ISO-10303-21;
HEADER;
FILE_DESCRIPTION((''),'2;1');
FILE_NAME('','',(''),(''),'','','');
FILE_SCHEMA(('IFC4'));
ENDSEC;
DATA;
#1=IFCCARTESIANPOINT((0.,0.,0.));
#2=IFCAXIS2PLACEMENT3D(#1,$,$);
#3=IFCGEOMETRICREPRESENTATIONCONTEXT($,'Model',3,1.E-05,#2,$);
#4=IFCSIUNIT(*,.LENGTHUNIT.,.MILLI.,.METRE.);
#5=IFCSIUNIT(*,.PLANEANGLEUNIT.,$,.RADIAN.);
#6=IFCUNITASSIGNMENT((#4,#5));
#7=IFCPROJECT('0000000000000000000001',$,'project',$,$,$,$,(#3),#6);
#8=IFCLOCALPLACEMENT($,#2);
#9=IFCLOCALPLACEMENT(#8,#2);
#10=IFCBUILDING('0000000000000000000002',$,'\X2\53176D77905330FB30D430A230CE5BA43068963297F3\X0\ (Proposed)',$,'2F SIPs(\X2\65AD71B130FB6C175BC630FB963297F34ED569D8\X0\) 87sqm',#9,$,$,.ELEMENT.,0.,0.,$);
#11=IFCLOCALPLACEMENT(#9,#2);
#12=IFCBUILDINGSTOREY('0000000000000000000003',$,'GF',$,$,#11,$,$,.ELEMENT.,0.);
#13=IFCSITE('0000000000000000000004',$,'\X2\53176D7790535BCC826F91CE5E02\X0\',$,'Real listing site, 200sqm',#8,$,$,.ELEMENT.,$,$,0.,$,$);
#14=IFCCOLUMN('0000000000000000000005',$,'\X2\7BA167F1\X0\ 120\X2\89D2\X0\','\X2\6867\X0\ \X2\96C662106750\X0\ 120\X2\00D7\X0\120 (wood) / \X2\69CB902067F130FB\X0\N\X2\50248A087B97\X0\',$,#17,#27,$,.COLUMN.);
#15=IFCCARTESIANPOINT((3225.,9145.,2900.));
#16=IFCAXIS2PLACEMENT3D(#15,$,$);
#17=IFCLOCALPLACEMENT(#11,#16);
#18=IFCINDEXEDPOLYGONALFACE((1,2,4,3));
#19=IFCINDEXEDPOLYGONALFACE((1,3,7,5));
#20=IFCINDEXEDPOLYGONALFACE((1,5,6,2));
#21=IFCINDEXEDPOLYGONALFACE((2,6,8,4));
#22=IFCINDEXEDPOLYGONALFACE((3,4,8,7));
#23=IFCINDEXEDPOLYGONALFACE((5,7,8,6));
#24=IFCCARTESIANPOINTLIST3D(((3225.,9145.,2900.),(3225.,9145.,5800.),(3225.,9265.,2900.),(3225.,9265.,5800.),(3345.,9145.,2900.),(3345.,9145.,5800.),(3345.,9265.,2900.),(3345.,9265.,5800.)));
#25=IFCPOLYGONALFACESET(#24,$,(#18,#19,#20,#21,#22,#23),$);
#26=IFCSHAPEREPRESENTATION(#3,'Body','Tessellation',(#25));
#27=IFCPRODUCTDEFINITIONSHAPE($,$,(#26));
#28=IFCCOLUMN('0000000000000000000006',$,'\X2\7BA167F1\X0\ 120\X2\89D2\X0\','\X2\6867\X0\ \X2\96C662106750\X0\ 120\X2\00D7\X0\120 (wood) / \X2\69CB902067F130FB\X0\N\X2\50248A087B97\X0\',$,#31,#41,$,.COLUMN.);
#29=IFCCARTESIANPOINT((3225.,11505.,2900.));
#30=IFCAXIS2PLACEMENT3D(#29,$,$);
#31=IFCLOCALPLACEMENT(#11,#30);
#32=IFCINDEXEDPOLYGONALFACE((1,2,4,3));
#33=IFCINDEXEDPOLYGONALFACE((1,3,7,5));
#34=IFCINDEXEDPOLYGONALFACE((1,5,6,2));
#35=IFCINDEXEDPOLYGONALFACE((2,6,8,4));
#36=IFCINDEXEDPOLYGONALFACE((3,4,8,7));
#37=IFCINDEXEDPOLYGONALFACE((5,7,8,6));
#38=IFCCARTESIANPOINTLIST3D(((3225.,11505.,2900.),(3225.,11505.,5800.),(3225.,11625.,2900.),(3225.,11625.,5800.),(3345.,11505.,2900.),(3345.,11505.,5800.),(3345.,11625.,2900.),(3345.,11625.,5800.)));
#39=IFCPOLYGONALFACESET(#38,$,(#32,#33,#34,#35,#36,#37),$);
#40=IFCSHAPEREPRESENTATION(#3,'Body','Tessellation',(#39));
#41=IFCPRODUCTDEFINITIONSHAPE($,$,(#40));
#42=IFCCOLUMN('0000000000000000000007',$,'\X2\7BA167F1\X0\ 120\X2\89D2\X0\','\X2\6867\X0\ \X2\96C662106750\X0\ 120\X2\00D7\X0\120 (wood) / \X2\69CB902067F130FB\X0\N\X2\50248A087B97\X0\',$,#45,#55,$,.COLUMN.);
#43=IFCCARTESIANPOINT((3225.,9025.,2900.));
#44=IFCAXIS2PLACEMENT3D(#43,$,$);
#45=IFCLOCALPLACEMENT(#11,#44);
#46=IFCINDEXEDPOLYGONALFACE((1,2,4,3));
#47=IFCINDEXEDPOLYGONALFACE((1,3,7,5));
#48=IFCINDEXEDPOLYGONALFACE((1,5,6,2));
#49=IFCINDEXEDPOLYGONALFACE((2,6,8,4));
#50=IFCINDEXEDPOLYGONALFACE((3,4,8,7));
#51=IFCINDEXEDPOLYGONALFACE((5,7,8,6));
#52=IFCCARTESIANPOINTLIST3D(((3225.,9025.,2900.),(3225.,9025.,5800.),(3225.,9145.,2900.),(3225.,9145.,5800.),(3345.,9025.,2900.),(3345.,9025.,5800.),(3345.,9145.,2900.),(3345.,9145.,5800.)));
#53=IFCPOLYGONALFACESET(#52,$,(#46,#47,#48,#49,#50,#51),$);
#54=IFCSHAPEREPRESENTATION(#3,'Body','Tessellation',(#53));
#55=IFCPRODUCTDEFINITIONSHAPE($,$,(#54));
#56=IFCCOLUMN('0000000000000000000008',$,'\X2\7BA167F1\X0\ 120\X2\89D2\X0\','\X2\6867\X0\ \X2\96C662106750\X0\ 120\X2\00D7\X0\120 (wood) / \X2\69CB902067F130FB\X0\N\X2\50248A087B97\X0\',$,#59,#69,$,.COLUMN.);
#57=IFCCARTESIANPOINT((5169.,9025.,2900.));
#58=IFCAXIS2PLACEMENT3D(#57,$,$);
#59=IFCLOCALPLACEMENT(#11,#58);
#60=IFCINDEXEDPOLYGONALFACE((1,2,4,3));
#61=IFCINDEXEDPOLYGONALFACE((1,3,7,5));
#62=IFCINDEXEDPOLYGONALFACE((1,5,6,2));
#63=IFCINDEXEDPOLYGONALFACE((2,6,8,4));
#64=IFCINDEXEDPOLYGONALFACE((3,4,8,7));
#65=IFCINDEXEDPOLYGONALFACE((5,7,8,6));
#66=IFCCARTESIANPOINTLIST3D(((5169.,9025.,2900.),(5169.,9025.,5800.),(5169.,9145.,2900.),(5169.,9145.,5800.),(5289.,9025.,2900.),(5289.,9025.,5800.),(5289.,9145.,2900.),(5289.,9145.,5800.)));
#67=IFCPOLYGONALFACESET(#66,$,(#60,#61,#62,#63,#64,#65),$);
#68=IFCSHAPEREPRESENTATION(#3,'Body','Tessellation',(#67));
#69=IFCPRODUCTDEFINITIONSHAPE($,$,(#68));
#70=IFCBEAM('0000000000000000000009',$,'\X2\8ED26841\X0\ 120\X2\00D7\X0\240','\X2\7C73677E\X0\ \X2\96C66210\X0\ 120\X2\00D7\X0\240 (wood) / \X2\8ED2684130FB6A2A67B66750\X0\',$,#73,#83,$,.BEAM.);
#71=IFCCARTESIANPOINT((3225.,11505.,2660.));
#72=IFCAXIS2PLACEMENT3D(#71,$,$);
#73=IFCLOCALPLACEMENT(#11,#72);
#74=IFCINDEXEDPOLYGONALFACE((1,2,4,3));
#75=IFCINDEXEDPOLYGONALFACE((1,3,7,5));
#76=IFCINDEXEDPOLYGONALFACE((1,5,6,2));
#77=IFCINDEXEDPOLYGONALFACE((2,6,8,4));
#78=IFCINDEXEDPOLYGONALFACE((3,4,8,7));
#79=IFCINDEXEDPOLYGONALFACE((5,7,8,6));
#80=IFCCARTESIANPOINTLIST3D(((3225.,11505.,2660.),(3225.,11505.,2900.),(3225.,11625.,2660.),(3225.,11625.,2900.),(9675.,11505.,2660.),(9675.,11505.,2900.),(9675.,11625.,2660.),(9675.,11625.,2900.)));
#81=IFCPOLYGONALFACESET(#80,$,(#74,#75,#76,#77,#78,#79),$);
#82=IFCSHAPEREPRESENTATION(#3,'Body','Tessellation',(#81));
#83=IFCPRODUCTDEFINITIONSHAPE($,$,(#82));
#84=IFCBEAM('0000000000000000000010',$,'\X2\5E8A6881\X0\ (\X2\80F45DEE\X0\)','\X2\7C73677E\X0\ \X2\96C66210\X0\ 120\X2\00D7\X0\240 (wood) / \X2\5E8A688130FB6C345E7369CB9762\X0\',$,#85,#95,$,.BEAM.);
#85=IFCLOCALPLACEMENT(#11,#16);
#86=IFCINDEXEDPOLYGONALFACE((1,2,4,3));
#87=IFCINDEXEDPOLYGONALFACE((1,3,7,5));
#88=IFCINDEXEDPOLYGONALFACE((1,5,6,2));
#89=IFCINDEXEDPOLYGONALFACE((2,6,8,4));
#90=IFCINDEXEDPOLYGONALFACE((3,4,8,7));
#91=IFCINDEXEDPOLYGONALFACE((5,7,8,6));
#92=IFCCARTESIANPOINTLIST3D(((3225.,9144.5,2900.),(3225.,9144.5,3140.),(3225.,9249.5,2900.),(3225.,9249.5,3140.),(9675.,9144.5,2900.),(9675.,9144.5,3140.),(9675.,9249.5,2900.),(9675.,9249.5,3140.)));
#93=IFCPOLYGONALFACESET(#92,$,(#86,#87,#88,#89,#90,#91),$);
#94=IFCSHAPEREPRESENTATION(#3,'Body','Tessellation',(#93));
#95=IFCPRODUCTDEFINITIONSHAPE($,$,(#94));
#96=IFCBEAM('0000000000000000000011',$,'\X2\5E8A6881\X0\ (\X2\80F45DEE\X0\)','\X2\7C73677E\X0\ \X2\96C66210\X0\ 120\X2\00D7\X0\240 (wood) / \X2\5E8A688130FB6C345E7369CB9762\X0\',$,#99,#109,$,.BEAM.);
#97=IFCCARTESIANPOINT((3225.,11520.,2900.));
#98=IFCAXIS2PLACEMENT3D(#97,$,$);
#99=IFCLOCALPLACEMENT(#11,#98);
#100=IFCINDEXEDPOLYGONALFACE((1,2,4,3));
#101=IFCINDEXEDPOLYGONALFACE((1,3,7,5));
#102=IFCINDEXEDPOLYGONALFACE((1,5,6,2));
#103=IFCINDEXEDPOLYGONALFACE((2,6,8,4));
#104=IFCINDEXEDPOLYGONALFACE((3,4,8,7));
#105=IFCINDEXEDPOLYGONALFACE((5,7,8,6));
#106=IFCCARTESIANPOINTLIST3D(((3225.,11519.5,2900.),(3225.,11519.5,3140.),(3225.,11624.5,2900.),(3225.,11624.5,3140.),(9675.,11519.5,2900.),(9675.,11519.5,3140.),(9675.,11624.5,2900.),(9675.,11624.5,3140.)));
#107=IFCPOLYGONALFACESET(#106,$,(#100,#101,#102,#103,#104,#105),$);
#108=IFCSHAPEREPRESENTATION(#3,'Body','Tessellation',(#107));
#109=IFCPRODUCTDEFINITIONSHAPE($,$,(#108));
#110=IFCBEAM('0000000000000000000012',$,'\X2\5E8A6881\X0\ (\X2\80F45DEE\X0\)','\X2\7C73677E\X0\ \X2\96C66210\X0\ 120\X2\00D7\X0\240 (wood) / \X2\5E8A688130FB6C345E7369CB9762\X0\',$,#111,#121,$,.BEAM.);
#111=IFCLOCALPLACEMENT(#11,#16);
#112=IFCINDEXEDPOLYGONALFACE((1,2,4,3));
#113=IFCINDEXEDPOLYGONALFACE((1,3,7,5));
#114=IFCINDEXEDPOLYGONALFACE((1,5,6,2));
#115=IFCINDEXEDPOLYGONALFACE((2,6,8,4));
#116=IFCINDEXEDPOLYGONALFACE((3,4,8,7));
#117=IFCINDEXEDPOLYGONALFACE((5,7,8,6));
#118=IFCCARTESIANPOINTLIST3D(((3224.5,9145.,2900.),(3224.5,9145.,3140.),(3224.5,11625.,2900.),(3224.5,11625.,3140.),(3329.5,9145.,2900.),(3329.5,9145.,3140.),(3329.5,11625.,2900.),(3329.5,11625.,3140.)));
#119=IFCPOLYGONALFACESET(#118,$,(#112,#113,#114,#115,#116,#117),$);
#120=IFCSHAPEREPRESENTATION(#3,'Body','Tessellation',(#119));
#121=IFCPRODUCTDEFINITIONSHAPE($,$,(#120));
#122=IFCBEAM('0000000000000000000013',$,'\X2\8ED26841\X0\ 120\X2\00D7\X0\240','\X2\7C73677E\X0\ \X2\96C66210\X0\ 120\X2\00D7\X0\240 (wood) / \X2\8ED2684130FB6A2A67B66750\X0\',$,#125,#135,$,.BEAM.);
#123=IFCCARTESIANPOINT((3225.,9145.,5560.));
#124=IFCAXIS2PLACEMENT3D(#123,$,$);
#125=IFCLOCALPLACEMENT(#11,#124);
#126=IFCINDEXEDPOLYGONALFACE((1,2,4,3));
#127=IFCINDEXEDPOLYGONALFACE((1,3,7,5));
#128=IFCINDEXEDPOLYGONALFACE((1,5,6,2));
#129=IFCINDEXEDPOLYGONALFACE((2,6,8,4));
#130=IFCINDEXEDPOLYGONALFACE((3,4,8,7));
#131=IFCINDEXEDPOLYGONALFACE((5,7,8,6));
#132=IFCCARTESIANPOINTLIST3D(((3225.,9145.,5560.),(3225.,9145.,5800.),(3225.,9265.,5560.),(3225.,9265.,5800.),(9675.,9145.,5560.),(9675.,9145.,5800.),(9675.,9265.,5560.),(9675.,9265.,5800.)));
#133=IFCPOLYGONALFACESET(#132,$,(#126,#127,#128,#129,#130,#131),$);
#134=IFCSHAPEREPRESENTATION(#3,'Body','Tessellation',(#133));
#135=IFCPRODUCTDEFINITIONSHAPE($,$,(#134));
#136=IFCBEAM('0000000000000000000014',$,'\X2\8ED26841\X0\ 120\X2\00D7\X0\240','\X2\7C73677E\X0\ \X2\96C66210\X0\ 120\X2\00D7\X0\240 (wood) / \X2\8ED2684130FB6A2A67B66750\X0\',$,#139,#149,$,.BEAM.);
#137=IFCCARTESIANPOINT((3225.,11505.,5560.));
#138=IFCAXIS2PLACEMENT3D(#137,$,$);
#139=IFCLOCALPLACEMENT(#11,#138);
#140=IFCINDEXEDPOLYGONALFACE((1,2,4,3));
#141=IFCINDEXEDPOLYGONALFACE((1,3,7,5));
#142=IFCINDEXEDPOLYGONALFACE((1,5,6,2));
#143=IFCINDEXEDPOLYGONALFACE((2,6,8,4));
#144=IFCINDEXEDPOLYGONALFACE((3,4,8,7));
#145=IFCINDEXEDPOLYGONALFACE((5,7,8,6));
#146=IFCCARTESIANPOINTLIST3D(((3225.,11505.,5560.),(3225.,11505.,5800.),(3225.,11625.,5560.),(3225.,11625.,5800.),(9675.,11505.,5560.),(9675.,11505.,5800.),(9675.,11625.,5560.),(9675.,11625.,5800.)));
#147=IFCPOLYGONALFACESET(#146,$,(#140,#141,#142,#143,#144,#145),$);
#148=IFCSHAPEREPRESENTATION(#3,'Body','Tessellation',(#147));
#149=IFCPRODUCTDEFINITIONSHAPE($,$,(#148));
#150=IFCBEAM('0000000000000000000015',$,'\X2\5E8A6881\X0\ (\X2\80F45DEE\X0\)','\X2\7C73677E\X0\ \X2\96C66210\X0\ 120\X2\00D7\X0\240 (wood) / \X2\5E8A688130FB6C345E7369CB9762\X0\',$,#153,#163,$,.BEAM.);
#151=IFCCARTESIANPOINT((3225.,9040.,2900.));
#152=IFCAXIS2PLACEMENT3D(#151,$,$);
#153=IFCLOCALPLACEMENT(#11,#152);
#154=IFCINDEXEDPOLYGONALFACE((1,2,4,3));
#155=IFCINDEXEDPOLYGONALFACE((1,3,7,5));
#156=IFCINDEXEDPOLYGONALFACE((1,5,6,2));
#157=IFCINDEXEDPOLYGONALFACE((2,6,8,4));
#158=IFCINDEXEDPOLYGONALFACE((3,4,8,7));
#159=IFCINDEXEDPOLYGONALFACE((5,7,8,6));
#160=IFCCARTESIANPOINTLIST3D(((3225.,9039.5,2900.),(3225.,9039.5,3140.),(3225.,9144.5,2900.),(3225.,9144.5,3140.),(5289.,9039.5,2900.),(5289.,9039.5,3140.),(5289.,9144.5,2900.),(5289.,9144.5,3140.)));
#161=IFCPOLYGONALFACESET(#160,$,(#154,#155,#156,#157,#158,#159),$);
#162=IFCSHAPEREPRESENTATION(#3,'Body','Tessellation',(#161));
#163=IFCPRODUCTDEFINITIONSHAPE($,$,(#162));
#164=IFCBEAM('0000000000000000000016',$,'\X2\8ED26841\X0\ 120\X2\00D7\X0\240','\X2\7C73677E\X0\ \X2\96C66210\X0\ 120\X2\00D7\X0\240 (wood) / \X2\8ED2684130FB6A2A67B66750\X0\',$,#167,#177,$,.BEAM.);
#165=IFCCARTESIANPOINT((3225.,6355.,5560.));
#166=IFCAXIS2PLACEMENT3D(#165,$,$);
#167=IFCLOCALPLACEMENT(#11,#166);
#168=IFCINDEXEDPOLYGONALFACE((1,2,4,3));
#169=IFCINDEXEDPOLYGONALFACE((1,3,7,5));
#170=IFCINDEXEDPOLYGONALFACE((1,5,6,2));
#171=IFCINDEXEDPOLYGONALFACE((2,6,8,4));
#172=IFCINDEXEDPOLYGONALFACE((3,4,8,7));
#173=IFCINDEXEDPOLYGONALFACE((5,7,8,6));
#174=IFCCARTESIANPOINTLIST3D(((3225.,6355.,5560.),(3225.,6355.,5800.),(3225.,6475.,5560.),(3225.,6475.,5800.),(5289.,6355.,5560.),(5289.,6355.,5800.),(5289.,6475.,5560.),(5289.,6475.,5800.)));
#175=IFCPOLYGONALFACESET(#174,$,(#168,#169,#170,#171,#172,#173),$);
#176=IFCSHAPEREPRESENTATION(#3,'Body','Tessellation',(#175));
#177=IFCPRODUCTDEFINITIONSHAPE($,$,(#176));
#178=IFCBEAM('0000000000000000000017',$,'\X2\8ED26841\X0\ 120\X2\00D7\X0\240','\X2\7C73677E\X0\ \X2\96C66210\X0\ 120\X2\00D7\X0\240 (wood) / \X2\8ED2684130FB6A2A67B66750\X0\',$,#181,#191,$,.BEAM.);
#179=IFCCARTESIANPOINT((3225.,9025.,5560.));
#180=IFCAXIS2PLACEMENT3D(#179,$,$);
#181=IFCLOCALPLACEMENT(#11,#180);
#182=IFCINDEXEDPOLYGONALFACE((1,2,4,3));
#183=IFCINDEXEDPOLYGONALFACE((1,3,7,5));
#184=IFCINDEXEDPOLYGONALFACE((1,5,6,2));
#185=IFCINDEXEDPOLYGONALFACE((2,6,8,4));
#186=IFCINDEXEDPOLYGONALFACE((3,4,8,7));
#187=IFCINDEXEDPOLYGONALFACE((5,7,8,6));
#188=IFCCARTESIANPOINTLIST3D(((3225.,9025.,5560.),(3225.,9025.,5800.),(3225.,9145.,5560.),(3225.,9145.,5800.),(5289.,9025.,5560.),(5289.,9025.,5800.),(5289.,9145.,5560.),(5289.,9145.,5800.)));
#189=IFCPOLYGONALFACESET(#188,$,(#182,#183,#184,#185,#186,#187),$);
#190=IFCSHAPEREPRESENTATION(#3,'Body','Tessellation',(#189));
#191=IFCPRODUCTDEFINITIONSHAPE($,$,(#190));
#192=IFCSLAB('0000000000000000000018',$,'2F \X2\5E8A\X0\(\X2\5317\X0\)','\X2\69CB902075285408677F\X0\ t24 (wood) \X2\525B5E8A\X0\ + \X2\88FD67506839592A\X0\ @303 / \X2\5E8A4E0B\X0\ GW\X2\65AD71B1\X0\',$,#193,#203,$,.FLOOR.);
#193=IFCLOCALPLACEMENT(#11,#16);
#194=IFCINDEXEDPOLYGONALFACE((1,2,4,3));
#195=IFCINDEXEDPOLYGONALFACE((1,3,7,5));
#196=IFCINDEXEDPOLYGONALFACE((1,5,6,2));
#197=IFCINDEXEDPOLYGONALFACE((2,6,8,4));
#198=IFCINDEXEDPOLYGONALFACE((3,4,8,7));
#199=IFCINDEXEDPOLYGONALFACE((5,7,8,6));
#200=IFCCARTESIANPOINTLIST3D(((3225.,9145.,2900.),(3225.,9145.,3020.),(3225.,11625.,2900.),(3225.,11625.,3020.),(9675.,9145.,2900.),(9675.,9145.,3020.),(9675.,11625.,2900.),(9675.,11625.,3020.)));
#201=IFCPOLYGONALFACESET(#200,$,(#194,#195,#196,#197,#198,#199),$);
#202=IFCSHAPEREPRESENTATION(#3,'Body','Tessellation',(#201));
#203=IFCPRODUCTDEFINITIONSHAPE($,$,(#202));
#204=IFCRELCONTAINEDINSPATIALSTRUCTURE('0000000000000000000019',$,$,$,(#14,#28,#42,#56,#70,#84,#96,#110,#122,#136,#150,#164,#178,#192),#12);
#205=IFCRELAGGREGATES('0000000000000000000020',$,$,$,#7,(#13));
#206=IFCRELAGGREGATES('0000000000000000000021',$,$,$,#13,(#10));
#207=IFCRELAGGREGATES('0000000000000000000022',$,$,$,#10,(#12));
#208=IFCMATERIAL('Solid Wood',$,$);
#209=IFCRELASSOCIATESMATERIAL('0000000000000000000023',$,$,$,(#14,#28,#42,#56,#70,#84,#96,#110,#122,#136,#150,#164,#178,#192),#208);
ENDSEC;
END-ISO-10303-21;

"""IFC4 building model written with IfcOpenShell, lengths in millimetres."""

from ifc_helpers import new_model, si_unit, frame, frame_2d, origin, place, context, project, spatial, rectangle, extrude, material, element, save


model = new_model("IFC4")

# Units and contexts
model_context = context("Model", 3, precision=1e-05, world=origin())
ifc_project = project(units=[si_unit("LENGTHUNIT", "METRE", prefix="MILLI"), si_unit("PLANEANGLEUNIT", "RADIAN")], contexts=[model_context])

# Site, building, storey
site_placement = place(None, origin())
site = spatial("IfcSite", under=ifc_project, at=site_placement, Name="北海道富良野市", ObjectType="Real listing site, 200sqm", CompositionType="ELEMENT", RefElevation=0.0)
building_placement = place(site_placement, origin())
building = spatial("IfcBuilding", under=site, at=building_placement, Name="北海道・ピアノ室と防音 (Proposed)", ObjectType="2F SIPs(断熱・気密・防音仕様) 87sqm", CompositionType="ELEMENT", ElevationOfRefHeight=0.0, ElevationOfTerrain=0.0)
storey_placement = place(building_placement, origin())
storey = spatial("IfcBuildingStorey", under=building, at=storey_placement, Name="GF", CompositionType="ELEMENT", Elevation=0.0)

# Columns
ifc_material_1 = material(Name="Solid Wood")
column_1_placement = place(storey_placement, frame((3225.0, 9145.0, 2900.0)))
element("IfcColumn", 1, at=column_1_placement, inside=storey, material=ifc_material_1, Name="管柱 120角", Description="桧 集成材 120×120 (wood) / 構造柱・N値計算", PredefinedType="COLUMN", context=model_context, shape_type="SweptSolid", body=[
    extrude(rectangle(XDim=120.0, YDim=120.0, at=frame_2d((60.0, 60.0))), frame((3225.0, 9145.0, 2900.0)), (0.0, 0.0, 1.0), 2900.0),
])
column_2_placement = place(storey_placement, frame((3225.0, 11505.0, 2900.0)))
element("IfcColumn", 2, at=column_2_placement, inside=storey, material=ifc_material_1, Name="管柱 120角", Description="桧 集成材 120×120 (wood) / 構造柱・N値計算", PredefinedType="COLUMN", context=model_context, shape_type="SweptSolid", body=[
    extrude(rectangle(XDim=120.0, YDim=120.0, at=frame_2d((60.0, 60.0))), frame((3225.0, 11505.0, 2900.0)), (0.0, 0.0, 1.0), 2900.0),
])
column_3_placement = place(storey_placement, frame((3225.0, 9025.0, 2900.0)))
element("IfcColumn", 3, at=column_3_placement, inside=storey, material=ifc_material_1, Name="管柱 120角", Description="桧 集成材 120×120 (wood) / 構造柱・N値計算", PredefinedType="COLUMN", context=model_context, shape_type="SweptSolid", body=[
    extrude(rectangle(XDim=120.0, YDim=120.0, at=frame_2d((60.0, 60.0))), frame((3225.0, 9025.0, 2900.0)), (0.0, 0.0, 1.0), 2900.0),
])
column_4_placement = place(storey_placement, frame((5169.0, 9025.0, 2900.0)))
element("IfcColumn", 4, at=column_4_placement, inside=storey, material=ifc_material_1, Name="管柱 120角", Description="桧 集成材 120×120 (wood) / 構造柱・N値計算", PredefinedType="COLUMN", context=model_context, shape_type="SweptSolid", body=[
    extrude(rectangle(XDim=120.0, YDim=120.0, at=frame_2d((60.0, 60.0))), frame((5169.0, 9025.0, 2900.0)), (0.0, 0.0, 1.0), 2900.0),
])

# Beams
beam_1_placement = place(storey_placement, frame((3225.0, 11505.0, 2660.0)))
element("IfcBeam", 5, at=beam_1_placement, inside=storey, material=ifc_material_1, Name="軒桁 120×240", Description="米松 集成 120×240 (wood) / 軒桁・横架材", PredefinedType="BEAM", context=model_context, shape_type="SweptSolid", body=[
    extrude(rectangle(XDim=6450.0, YDim=120.0, at=frame_2d((3225.0, 60.0))), frame((3225.0, 11505.0, 2660.0)), (0.0, 0.0, 1.0), 240.0),
])
beam_2_placement = place(storey_placement, frame((3225.0, 9145.0, 2900.0)))
element("IfcBeam", 6, at=beam_2_placement, inside=storey, material=ifc_material_1, Name="床梁 (胴差)", Description="米松 集成 120×240 (wood) / 床梁・水平構面", PredefinedType="BEAM", context=model_context, shape_type="SweptSolid", body=[
    extrude(rectangle(XDim=6450.0, YDim=105.0, at=frame_2d((3225.0, 52.0))), frame((3225.0, 9145.0, 2900.0)), (0.0, 0.0, 1.0), 240.0),
])
beam_3_placement = place(storey_placement, frame((3225.0, 11520.0, 2900.0)))
element("IfcBeam", 7, at=beam_3_placement, inside=storey, material=ifc_material_1, Name="床梁 (胴差)", Description="米松 集成 120×240 (wood) / 床梁・水平構面", PredefinedType="BEAM", context=model_context, shape_type="SweptSolid", body=[
    extrude(rectangle(XDim=6450.0, YDim=105.0, at=frame_2d((3225.0, 52.0))), frame((3225.0, 11520.0, 2900.0)), (0.0, 0.0, 1.0), 240.0),
])
beam_4_placement = place(storey_placement, frame((3225.0, 9145.0, 2900.0)))
element("IfcBeam", 8, at=beam_4_placement, inside=storey, material=ifc_material_1, Name="床梁 (胴差)", Description="米松 集成 120×240 (wood) / 床梁・水平構面", PredefinedType="BEAM", context=model_context, shape_type="SweptSolid", body=[
    extrude(rectangle(XDim=105.0, YDim=2480.0, at=frame_2d((52.0, 1240.0))), frame((3225.0, 9145.0, 2900.0)), (0.0, 0.0, 1.0), 240.0),
])
beam_5_placement = place(storey_placement, frame((3225.0, 9145.0, 5560.0)))
element("IfcBeam", 9, at=beam_5_placement, inside=storey, material=ifc_material_1, Name="軒桁 120×240", Description="米松 集成 120×240 (wood) / 軒桁・横架材", PredefinedType="BEAM", context=model_context, shape_type="SweptSolid", body=[
    extrude(rectangle(XDim=6450.0, YDim=120.0, at=frame_2d((3225.0, 60.0))), frame((3225.0, 9145.0, 5560.0)), (0.0, 0.0, 1.0), 240.0),
])
beam_6_placement = place(storey_placement, frame((3225.0, 11505.0, 5560.0)))
element("IfcBeam", 10, at=beam_6_placement, inside=storey, material=ifc_material_1, Name="軒桁 120×240", Description="米松 集成 120×240 (wood) / 軒桁・横架材", PredefinedType="BEAM", context=model_context, shape_type="SweptSolid", body=[
    extrude(rectangle(XDim=6450.0, YDim=120.0, at=frame_2d((3225.0, 60.0))), frame((3225.0, 11505.0, 5560.0)), (0.0, 0.0, 1.0), 240.0),
])
beam_7_placement = place(storey_placement, frame((3225.0, 9040.0, 2900.0)))
element("IfcBeam", 11, at=beam_7_placement, inside=storey, material=ifc_material_1, Name="床梁 (胴差)", Description="米松 集成 120×240 (wood) / 床梁・水平構面", PredefinedType="BEAM", context=model_context, shape_type="SweptSolid", body=[
    extrude(rectangle(XDim=2064.0, YDim=105.0, at=frame_2d((1032.0, 52.0))), frame((3225.0, 9040.0, 2900.0)), (0.0, 0.0, 1.0), 240.0),
])
beam_8_placement = place(storey_placement, frame((3225.0, 6355.0, 5560.0)))
element("IfcBeam", 12, at=beam_8_placement, inside=storey, material=ifc_material_1, Name="軒桁 120×240", Description="米松 集成 120×240 (wood) / 軒桁・横架材", PredefinedType="BEAM", context=model_context, shape_type="SweptSolid", body=[
    extrude(rectangle(XDim=2064.0, YDim=120.0, at=frame_2d((1032.0, 60.0))), frame((3225.0, 6355.0, 5560.0)), (0.0, 0.0, 1.0), 240.0),
])
beam_9_placement = place(storey_placement, frame((3225.0, 9025.0, 5560.0)))
element("IfcBeam", 13, at=beam_9_placement, inside=storey, material=ifc_material_1, Name="軒桁 120×240", Description="米松 集成 120×240 (wood) / 軒桁・横架材", PredefinedType="BEAM", context=model_context, shape_type="SweptSolid", body=[
    extrude(rectangle(XDim=2064.0, YDim=120.0, at=frame_2d((1032.0, 60.0))), frame((3225.0, 9025.0, 5560.0)), (0.0, 0.0, 1.0), 240.0),
])

# Slab
slab_placement = place(storey_placement, frame((3225.0, 9145.0, 2900.0)))
element("IfcSlab", 14, at=slab_placement, inside=storey, material=ifc_material_1, Name="2F 床(北)", Description="構造用合板 t24 (wood) 剛床 + 製材根太 @303 / 床下 GW断熱", PredefinedType="FLOOR", context=model_context, shape_type="SweptSolid", body=[
    extrude(rectangle(XDim=6450.0, YDim=2480.0, at=frame_2d((3225.0, 1240.0))), frame((3225.0, 9145.0, 2900.0)), (0.0, 0.0, 1.0), 120.0),
])

save(model, "model.ifc")
